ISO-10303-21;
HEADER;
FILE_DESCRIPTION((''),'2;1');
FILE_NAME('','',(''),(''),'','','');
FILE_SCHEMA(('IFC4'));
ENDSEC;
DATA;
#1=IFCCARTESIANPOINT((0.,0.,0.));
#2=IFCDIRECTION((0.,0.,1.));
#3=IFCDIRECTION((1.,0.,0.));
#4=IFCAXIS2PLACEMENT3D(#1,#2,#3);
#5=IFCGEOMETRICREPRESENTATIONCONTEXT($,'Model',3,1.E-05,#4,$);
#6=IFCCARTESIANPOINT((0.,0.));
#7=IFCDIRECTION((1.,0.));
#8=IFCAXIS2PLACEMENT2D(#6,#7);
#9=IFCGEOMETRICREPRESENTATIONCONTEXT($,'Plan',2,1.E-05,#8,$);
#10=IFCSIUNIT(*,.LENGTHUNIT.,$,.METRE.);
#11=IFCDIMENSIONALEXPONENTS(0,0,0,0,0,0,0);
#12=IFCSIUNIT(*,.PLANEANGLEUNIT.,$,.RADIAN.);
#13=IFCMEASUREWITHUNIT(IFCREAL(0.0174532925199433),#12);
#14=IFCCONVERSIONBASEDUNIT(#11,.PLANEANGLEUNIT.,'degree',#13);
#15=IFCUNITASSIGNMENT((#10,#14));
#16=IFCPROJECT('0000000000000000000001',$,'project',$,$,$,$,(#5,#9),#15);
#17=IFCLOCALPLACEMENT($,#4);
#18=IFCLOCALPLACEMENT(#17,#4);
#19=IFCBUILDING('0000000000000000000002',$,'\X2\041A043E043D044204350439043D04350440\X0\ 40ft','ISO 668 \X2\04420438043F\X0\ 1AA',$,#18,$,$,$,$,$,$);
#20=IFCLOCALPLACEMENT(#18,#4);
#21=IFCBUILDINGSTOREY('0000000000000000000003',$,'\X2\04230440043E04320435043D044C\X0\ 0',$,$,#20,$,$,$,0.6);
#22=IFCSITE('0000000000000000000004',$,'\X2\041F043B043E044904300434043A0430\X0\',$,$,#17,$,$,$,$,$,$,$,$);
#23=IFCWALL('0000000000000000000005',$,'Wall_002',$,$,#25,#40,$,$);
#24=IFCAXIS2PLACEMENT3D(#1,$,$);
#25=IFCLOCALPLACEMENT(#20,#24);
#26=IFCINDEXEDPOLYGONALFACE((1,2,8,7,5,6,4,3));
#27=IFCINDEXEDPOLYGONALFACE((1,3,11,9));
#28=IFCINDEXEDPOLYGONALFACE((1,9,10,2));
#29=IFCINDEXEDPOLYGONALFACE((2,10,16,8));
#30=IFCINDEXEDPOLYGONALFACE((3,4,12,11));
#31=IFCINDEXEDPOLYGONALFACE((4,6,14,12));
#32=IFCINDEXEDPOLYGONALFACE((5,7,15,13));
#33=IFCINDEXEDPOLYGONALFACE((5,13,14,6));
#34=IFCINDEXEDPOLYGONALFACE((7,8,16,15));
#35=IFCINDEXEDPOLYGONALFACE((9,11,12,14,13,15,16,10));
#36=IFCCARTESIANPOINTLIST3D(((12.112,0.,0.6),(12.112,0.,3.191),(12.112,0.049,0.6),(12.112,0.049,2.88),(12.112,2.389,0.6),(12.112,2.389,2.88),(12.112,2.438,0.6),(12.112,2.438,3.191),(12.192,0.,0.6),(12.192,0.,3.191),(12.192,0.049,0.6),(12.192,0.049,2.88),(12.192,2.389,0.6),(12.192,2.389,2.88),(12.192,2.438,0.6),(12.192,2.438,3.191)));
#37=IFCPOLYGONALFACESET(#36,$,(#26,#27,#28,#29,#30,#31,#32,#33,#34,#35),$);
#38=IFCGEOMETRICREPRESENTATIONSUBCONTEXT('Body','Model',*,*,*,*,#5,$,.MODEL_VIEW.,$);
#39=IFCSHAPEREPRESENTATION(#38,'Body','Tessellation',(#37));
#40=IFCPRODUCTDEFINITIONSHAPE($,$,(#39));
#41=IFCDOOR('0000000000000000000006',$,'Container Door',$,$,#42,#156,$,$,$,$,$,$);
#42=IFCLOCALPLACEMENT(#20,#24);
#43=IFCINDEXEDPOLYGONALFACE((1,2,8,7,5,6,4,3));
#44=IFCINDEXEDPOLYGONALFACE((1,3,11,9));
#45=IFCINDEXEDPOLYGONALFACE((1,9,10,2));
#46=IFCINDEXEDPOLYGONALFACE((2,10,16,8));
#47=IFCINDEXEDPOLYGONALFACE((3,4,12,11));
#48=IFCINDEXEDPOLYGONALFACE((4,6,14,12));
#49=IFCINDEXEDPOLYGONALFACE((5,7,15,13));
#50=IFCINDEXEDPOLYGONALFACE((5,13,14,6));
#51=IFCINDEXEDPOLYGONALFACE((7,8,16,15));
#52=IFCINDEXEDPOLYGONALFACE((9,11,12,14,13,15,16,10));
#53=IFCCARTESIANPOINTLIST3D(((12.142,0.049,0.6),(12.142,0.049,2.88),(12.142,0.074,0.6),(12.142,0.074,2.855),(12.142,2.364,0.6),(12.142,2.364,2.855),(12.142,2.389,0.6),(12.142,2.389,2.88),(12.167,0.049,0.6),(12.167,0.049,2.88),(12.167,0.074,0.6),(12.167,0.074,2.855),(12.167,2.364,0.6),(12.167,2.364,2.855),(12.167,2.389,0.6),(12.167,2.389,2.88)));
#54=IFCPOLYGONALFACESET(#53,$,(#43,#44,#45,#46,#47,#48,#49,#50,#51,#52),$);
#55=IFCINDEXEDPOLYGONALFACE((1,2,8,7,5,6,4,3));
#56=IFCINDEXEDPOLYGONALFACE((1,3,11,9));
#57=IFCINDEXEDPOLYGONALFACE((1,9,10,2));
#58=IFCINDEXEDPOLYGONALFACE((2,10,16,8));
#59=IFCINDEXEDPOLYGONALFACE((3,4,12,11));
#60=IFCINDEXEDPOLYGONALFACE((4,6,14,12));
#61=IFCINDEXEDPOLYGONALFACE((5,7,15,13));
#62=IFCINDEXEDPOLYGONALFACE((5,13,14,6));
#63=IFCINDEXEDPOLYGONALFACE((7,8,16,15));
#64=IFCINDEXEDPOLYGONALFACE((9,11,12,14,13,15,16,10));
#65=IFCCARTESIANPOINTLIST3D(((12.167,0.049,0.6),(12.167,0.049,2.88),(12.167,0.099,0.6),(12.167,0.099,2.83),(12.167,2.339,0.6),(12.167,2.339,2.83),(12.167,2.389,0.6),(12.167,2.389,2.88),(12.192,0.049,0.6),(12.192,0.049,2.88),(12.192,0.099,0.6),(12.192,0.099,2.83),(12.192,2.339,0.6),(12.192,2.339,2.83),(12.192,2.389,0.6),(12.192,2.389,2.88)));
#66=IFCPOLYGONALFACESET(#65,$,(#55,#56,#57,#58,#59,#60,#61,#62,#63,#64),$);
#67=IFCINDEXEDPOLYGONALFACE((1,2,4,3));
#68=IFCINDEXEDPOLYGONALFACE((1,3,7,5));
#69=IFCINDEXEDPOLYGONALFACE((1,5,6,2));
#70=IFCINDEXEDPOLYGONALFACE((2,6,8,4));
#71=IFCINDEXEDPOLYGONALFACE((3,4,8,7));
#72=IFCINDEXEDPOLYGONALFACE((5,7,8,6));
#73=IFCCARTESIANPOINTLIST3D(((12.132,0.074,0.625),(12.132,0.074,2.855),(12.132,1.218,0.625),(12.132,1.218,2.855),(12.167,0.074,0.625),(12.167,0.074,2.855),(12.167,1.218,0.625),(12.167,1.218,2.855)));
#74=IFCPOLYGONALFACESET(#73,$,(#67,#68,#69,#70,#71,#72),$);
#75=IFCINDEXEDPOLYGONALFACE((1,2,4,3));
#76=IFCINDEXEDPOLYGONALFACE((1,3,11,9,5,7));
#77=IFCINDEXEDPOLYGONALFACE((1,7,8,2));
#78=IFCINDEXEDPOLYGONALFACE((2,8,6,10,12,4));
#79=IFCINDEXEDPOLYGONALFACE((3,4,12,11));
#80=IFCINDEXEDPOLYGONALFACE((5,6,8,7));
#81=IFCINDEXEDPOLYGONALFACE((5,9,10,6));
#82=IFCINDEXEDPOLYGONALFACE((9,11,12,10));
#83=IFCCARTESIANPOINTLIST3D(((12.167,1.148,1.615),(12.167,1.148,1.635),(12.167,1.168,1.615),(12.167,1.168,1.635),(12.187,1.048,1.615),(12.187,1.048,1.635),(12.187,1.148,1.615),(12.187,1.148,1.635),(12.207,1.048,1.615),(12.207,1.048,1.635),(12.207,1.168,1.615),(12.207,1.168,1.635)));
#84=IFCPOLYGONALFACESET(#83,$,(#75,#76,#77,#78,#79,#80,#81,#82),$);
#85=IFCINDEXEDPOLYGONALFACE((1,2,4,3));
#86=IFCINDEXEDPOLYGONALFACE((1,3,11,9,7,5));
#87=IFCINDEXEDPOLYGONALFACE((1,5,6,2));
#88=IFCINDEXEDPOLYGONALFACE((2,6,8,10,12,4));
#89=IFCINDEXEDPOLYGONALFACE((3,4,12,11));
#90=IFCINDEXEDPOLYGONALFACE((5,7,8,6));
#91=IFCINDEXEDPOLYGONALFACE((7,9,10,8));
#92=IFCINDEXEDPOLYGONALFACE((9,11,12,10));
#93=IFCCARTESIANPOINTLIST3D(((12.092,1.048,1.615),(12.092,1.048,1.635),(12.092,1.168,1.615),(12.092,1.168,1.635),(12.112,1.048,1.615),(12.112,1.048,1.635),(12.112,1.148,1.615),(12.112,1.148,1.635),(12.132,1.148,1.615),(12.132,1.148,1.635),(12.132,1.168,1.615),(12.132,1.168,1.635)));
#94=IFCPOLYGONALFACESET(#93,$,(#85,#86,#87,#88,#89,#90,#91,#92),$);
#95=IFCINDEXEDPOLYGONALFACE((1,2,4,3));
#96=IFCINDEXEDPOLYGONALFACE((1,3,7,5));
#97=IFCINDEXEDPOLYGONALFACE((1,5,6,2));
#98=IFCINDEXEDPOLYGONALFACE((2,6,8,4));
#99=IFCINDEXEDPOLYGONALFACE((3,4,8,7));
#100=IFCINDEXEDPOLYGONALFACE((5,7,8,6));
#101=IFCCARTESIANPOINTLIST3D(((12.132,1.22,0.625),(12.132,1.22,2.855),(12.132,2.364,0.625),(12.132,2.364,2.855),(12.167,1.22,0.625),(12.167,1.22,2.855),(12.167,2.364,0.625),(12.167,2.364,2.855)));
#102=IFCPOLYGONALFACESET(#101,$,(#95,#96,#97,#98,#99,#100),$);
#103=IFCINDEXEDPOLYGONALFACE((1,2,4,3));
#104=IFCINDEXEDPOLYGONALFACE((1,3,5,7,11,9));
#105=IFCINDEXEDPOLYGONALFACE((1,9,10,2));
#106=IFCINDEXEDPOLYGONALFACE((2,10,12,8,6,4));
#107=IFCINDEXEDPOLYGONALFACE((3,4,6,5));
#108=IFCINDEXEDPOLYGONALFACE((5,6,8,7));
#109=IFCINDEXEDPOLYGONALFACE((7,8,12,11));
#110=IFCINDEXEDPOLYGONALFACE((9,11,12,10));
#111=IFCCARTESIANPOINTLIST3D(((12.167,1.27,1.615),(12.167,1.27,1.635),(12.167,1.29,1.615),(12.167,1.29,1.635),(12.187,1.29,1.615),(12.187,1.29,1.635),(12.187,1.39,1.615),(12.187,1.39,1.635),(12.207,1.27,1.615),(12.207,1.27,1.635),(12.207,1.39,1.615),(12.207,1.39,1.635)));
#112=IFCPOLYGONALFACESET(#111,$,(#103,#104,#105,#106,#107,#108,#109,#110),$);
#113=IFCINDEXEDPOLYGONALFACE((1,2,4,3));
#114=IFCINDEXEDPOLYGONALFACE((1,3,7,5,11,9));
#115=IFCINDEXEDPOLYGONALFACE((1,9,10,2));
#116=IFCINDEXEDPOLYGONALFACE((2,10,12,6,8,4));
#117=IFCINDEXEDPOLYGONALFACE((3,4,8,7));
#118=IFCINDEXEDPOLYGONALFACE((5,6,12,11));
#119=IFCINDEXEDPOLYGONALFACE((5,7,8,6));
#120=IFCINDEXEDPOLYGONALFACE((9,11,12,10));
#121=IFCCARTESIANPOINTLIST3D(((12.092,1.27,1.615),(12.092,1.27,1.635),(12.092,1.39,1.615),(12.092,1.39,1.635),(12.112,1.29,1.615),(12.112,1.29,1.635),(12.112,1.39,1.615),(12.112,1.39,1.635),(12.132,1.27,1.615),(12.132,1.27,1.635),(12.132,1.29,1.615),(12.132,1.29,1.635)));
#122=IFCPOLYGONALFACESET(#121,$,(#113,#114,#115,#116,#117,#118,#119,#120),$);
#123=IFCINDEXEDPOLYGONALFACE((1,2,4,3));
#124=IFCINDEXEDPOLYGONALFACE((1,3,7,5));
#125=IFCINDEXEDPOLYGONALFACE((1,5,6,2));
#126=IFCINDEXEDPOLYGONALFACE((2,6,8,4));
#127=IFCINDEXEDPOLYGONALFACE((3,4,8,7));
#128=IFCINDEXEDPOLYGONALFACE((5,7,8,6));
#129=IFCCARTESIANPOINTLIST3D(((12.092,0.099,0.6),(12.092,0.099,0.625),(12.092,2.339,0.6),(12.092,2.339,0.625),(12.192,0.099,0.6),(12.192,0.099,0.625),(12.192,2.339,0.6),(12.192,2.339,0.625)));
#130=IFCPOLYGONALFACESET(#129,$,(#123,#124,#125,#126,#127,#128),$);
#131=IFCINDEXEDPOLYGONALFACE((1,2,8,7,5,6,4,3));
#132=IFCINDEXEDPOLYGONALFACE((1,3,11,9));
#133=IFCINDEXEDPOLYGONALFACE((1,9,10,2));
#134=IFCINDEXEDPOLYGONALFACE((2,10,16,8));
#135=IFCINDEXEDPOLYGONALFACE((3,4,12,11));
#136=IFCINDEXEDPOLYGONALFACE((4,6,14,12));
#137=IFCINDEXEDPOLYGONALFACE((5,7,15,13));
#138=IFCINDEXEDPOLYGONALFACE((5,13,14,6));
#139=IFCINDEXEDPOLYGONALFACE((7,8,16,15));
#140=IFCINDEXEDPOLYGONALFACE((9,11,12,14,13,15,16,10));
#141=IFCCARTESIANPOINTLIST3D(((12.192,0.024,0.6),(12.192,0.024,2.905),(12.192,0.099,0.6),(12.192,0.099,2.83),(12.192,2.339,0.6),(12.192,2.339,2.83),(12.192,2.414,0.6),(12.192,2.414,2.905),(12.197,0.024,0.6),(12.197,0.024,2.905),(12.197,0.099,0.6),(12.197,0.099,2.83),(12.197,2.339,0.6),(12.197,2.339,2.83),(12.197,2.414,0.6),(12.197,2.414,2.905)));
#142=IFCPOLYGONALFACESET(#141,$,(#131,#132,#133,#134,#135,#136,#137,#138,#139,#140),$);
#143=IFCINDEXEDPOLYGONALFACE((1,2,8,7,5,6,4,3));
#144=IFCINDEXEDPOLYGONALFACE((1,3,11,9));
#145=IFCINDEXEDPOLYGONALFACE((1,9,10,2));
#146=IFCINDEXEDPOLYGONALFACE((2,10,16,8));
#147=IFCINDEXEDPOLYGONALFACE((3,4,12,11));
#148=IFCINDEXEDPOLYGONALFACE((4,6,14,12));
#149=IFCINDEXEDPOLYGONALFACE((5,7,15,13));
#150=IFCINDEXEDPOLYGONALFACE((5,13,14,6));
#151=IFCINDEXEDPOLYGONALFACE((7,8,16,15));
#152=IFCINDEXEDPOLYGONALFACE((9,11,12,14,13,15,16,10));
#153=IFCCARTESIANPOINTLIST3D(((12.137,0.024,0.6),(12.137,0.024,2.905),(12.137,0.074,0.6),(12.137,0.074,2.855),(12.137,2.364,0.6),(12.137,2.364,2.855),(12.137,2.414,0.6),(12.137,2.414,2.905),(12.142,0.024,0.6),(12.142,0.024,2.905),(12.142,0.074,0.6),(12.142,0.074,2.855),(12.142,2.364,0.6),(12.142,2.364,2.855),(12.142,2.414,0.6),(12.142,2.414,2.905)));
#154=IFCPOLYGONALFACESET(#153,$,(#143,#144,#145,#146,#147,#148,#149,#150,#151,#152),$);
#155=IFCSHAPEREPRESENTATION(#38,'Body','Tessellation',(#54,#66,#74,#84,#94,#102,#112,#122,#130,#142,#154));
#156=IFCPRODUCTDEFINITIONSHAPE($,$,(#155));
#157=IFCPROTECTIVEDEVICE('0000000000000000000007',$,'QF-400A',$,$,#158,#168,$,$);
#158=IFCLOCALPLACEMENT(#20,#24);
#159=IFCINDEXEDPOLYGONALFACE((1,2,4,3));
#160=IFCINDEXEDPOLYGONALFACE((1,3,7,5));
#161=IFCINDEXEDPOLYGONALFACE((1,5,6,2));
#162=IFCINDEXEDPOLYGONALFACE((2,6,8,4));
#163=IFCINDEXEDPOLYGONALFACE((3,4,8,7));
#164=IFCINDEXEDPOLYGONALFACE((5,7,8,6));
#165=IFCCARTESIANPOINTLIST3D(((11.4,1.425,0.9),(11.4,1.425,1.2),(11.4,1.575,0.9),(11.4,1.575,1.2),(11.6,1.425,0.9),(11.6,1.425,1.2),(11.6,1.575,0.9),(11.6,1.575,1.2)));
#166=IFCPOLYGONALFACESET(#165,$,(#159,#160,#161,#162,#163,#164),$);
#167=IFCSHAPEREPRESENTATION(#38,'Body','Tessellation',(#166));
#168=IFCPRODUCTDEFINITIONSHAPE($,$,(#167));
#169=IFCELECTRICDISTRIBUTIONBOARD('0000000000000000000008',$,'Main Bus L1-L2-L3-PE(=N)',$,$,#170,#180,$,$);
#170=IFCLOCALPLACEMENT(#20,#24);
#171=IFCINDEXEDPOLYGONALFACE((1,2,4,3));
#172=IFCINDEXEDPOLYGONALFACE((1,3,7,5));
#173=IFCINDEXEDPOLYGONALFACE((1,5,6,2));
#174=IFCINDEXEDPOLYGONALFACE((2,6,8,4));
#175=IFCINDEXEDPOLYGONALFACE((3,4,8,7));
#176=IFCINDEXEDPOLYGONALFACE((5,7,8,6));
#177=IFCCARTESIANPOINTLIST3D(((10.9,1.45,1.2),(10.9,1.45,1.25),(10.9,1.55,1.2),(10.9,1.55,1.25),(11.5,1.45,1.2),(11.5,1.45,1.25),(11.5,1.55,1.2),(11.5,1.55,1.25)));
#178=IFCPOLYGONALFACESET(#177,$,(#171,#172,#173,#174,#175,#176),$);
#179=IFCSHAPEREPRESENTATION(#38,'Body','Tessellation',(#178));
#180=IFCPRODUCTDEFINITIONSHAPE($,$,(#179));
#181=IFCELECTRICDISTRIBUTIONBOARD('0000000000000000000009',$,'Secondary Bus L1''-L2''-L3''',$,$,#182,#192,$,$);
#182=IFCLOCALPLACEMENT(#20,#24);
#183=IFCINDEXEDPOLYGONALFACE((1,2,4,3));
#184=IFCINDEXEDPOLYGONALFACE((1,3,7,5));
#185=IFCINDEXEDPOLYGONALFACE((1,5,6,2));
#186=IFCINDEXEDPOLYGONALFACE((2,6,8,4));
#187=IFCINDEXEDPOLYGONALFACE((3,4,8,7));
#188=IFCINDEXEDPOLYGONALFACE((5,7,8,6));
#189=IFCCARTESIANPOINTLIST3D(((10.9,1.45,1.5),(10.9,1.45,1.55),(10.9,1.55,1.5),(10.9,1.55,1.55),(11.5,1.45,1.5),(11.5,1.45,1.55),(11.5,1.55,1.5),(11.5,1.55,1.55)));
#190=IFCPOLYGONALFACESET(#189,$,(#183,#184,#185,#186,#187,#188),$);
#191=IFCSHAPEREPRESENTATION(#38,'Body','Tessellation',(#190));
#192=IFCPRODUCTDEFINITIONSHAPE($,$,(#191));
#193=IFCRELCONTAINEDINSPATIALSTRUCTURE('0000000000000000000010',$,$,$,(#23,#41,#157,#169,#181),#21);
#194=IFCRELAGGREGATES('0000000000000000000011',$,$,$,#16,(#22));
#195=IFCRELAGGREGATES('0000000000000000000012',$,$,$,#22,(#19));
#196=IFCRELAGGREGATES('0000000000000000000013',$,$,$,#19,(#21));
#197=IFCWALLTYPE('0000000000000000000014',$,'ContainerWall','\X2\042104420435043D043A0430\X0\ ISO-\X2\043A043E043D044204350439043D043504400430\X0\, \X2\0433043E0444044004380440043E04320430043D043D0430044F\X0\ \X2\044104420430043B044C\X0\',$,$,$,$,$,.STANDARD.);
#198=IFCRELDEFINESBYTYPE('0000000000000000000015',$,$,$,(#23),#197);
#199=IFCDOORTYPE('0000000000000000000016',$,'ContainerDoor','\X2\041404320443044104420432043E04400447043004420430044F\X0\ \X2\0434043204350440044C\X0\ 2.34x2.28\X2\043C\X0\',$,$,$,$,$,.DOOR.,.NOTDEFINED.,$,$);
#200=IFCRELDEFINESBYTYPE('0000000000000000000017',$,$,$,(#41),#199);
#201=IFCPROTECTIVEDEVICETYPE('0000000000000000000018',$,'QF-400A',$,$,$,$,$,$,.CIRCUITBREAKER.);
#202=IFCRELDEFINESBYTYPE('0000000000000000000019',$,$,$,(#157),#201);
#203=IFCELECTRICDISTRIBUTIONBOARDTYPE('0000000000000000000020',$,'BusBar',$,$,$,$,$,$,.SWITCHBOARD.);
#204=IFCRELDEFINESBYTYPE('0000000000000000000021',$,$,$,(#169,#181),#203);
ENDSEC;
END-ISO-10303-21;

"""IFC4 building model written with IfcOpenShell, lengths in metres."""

from ifc_helpers import new_model, entity, si_unit, converted_unit, frame, origin_with_axes, origin_2d_with_axis, place, context, subcontext, project, spatial, line, indexed_curve, rectangle, outline, extrude, type_object, element, fill, save


model = new_model("IFC4")

# Units and contexts
model_context = context("Model", 3, precision=1e-05, world=origin_with_axes())
plan_context = context("Plan", 2, precision=1e-05, world=origin_2d_with_axis())
body_context = subcontext(model_context, "Body", "Model", "MODEL_VIEW")
ifc_project = project(units=[si_unit("LENGTHUNIT", "METRE"), converted_unit("PLANEANGLEUNIT", "degree", entity("IfcReal", 0.0174532925199433), si_unit("PLANEANGLEUNIT", "RADIAN"), dimensions=[0, 0, 0, 0, 0, 0, 0])], contexts=[model_context, plan_context])

# Site, building, storey
site_placement = place(None, origin_with_axes())
site = spatial("IfcSite", under=ifc_project, at=site_placement, Name="Площадка")
building_placement = place(site_placement, origin_with_axes())
building = spatial("IfcBuilding", under=site, at=building_placement, Name="Контейнер 40ft", Description="ISO 668 тип 1AA")
storey_placement = place(building_placement, origin_with_axes())
storey = spatial("IfcBuildingStorey", under=building, at=storey_placement, Name="Уровень 0", Elevation=0.6)

# Wall, opening, door
wall_type = type_object("IfcWallType", Name="ContainerWall", Description="Стенка ISO-контейнера, гофрированная сталь", PredefinedType="STANDARD")
wall_placement = place(storey_placement, frame((12.192, 0.0, 0.6), z_axis=(0.0, 0.0, 1.0), x_axis=(0.0, 1.0, 0.0)))
wall = element("IfcWall", 1, at=wall_placement, inside=storey, type_object=wall_type, Name="Wall_002", context=body_context, shape_type="SweptSolid", body=[
    extrude(outline(indexed_curve([(0.0, 0.0), (0.0, 0.08), (2.438, 0.08), (2.438, 0.0), (0.0, 0.0)], self_intersect=False)), origin_with_axes(), (0.0, 0.0, 1.0), 2.591),
])
opening_placement = place(wall_placement, frame((0.049, 0.0, 0.0), z_axis=(0.0, 0.0, 1.0), x_axis=(1.0, 0.0, 0.0)))
opening = element("IfcOpeningElement", 2, at=opening_placement, inside=storey, cuts=wall, PredefinedType="OPENING", context=body_context, shape_type="SweptSolid", body=[
    extrude(outline(indexed_curve([(0.0, 0.0), (0.0, 0.3), (2.34, 0.3), (2.34, 0.0), (0.0, 0.0)], self_intersect=False)), origin_with_axes(), (0.0, 0.0, 1.0), 2.28),
])
door_type = type_object("IfcDoorType", Name="ContainerDoor", Description="Двустворчатая дверь 2.34x2.28м", OperationType="NOTDEFINED", PredefinedType="DOOR")
door_placement = place(opening_placement, frame((0.0, 0.0, 0.0), z_axis=(0.0, 0.0, 1.0), x_axis=(1.0, 0.0, 0.0)))
door = element("IfcDoor", 3, at=door_placement, inside=storey, type_object=door_type, Name="Container Door", context=body_context, shape_type="SweptSolid", body=[
    extrude(outline(indexed_curve([(0.0, 0.0), (0.0, 2.28), (2.34, 2.28), (2.34, 0.0), (2.315, 0.0), (2.315, 2.255), (0.025, 2.255), (0.025, 0.0)], segments=[line(1, 2, 3, 4, 5, 6, 7, 8, 1)])), frame((0.0, 0.025, 0.0), z_axis=(0.0, -1.0, 0.0), x_axis=(1.0, 0.0, 0.0)), (0.0, 0.0, -1.0), 0.025),
    extrude(outline(indexed_curve([(0.0, 0.0), (0.0, 2.28), (2.34, 2.28), (2.34, 0.0), (2.29, 0.0), (2.29, 2.23), (0.05, 2.23), (0.05, 0.0)], segments=[line(1, 2, 3, 4, 5, 6, 7, 8, 1)])), frame((0.0, 0.0, 0.0), z_axis=(0.0, -1.0, 0.0), x_axis=(1.0, 0.0, 0.0)), (0.0, 0.0, -1.0), 0.025),
    extrude(outline(indexed_curve([(0.0, 0.0), (1.144, 0.0), (1.144, 0.035), (0.0, 0.035)], segments=[line(1, 2, 3, 4, 1)])), frame((0.025, 0.025, 0.025), z_axis=(0.0, 0.0, 1.0), x_axis=(1.0, 0.0, 0.0)), (0.0, 0.0, 1.0), 2.23),
    extrude(outline(indexed_curve([(0.0, 0.0), (0.0, -0.04), (-0.12, -0.04), (-0.12, -0.02), (-0.02, -0.02), (-0.02, 0.0)], segments=[line(1, 2, 3, 4, 5, 6, 1)])), frame((1.119, 0.025, 1.015), z_axis=(0.0, 0.0, 1.0), x_axis=(1.0, 0.0, 0.0)), (0.0, 0.0, 1.0), 0.02),
    extrude(outline(indexed_curve([(0.0, 0.0), (0.0, 0.04), (-0.12, 0.04), (-0.12, 0.02), (-0.02, 0.02), (-0.02, 0.0)], segments=[line(1, 2, 3, 4, 5, 6, 1)])), frame((1.119, 0.06, 1.015), z_axis=(0.0, 0.0, 1.0), x_axis=(1.0, 0.0, 0.0)), (0.0, 0.0, 1.0), 0.02),
    extrude(outline(indexed_curve([(0.0, 0.0), (-1.144, 0.0), (-1.144, 0.035), (0.0, 0.035)], segments=[line(1, 2, 3, 4, 1)])), frame((2.315, 0.025, 0.025), z_axis=(0.0, 0.0, 1.0), x_axis=(1.0, 0.0, 0.0)), (0.0, 0.0, 1.0), 2.23),
    extrude(outline(indexed_curve([(0.0, 0.0), (0.0, -0.04), (0.12, -0.04), (0.12, -0.02), (0.02, -0.02), (0.02, 0.0)], segments=[line(1, 2, 3, 4, 5, 6, 1)])), frame((1.221, 0.025, 1.015), z_axis=(0.0, 0.0, 1.0), x_axis=(1.0, 0.0, 0.0)), (0.0, 0.0, 1.0), 0.02),
    extrude(outline(indexed_curve([(0.0, 0.0), (0.0, 0.04), (0.12, 0.04), (0.12, 0.02), (0.02, 0.02), (0.02, 0.0)], segments=[line(1, 2, 3, 4, 5, 6, 1)])), frame((1.221, 0.06, 1.015), z_axis=(0.0, 0.0, 1.0), x_axis=(1.0, 0.0, 0.0)), (0.0, 0.0, 1.0), 0.02),
    extrude(outline(indexed_curve([(0.0, 0.0), (2.24, 0.0), (2.24, 0.1), (0.0, 0.1)], segments=[line(1, 2, 3, 4, 1)])), frame((0.05, 0.0, 0.0), z_axis=(0.0, 0.0, 1.0), x_axis=(1.0, 0.0, 0.0)), (0.0, 0.0, 1.0), 0.025),
    extrude(outline(indexed_curve([(0.0, 0.0), (0.0, 2.305), (2.39, 2.305), (2.39, 0.0), (2.315, 0.0), (2.315, 2.23), (0.075, 2.23), (0.075, 0.0)], segments=[line(1, 2, 3, 4, 5, 6, 7, 8, 1)])), frame((-0.025, -0.005, 0.0), z_axis=(0.0, -1.0, 0.0), x_axis=(1.0, 0.0, 0.0)), (0.0, 0.0, -1.0), 0.005),
    extrude(outline(indexed_curve([(0.0, 0.0), (0.0, 2.305), (2.39, 2.305), (2.39, 0.0), (2.34, 0.0), (2.34, 2.255), (0.05, 2.255), (0.05, 0.0)], segments=[line(1, 2, 3, 4, 5, 6, 7, 8, 1)])), frame((-0.025, 0.05, 0.0), z_axis=(0.0, -1.0, 0.0), x_axis=(1.0, 0.0, 0.0)), (0.0, 0.0, -1.0), 0.005),
])
fill(opening, door)

# Protective device
protective_device_type = type_object("IfcProtectiveDeviceType", Name="QF-400A", PredefinedType="CIRCUITBREAKER")
protective_device_placement = place(storey_placement, frame((11.5, 1.5, 0.9), z_axis=(0.0, 0.0, 1.0), x_axis=(1.0, 0.0, 0.0)))
element("IfcProtectiveDevice", 4, at=protective_device_placement, inside=storey, type_object=protective_device_type, Name="QF-400A", context=body_context, shape_type="SweptSolid", body=[
    extrude(rectangle(XDim=0.2, YDim=0.15), None, (0.0, 0.0, 1.0), 0.3),
])

# Electric distribution boards
electric_distribution_board_type = type_object("IfcElectricDistributionBoardType", Name="BusBar", PredefinedType="SWITCHBOARD")
for number, where, z_axis, x_axis, name in (
    (5, (11.2, 1.5, 1.2), (0.0, 0.0, 1.0), (1.0, 0.0, 0.0), "Main Bus L1-L2-L3-PE(=N)"),
    (6, (11.2, 1.5, 1.5), (0.0, 0.0, 1.0), (1.0, 0.0, 0.0), "Secondary Bus L1'-L2'-L3'"),
):
    element("IfcElectricDistributionBoard", number, at=place(storey_placement, frame(where, z_axis=z_axis, x_axis=x_axis)), inside=storey, type_object=electric_distribution_board_type, Name=name, context=body_context, shape_type="SweptSolid", body=[
        extrude(rectangle(XDim=0.6, YDim=0.1), None, (0.0, 0.0, 1.0), 0.05),
    ])

save(model, "model.ifc")
